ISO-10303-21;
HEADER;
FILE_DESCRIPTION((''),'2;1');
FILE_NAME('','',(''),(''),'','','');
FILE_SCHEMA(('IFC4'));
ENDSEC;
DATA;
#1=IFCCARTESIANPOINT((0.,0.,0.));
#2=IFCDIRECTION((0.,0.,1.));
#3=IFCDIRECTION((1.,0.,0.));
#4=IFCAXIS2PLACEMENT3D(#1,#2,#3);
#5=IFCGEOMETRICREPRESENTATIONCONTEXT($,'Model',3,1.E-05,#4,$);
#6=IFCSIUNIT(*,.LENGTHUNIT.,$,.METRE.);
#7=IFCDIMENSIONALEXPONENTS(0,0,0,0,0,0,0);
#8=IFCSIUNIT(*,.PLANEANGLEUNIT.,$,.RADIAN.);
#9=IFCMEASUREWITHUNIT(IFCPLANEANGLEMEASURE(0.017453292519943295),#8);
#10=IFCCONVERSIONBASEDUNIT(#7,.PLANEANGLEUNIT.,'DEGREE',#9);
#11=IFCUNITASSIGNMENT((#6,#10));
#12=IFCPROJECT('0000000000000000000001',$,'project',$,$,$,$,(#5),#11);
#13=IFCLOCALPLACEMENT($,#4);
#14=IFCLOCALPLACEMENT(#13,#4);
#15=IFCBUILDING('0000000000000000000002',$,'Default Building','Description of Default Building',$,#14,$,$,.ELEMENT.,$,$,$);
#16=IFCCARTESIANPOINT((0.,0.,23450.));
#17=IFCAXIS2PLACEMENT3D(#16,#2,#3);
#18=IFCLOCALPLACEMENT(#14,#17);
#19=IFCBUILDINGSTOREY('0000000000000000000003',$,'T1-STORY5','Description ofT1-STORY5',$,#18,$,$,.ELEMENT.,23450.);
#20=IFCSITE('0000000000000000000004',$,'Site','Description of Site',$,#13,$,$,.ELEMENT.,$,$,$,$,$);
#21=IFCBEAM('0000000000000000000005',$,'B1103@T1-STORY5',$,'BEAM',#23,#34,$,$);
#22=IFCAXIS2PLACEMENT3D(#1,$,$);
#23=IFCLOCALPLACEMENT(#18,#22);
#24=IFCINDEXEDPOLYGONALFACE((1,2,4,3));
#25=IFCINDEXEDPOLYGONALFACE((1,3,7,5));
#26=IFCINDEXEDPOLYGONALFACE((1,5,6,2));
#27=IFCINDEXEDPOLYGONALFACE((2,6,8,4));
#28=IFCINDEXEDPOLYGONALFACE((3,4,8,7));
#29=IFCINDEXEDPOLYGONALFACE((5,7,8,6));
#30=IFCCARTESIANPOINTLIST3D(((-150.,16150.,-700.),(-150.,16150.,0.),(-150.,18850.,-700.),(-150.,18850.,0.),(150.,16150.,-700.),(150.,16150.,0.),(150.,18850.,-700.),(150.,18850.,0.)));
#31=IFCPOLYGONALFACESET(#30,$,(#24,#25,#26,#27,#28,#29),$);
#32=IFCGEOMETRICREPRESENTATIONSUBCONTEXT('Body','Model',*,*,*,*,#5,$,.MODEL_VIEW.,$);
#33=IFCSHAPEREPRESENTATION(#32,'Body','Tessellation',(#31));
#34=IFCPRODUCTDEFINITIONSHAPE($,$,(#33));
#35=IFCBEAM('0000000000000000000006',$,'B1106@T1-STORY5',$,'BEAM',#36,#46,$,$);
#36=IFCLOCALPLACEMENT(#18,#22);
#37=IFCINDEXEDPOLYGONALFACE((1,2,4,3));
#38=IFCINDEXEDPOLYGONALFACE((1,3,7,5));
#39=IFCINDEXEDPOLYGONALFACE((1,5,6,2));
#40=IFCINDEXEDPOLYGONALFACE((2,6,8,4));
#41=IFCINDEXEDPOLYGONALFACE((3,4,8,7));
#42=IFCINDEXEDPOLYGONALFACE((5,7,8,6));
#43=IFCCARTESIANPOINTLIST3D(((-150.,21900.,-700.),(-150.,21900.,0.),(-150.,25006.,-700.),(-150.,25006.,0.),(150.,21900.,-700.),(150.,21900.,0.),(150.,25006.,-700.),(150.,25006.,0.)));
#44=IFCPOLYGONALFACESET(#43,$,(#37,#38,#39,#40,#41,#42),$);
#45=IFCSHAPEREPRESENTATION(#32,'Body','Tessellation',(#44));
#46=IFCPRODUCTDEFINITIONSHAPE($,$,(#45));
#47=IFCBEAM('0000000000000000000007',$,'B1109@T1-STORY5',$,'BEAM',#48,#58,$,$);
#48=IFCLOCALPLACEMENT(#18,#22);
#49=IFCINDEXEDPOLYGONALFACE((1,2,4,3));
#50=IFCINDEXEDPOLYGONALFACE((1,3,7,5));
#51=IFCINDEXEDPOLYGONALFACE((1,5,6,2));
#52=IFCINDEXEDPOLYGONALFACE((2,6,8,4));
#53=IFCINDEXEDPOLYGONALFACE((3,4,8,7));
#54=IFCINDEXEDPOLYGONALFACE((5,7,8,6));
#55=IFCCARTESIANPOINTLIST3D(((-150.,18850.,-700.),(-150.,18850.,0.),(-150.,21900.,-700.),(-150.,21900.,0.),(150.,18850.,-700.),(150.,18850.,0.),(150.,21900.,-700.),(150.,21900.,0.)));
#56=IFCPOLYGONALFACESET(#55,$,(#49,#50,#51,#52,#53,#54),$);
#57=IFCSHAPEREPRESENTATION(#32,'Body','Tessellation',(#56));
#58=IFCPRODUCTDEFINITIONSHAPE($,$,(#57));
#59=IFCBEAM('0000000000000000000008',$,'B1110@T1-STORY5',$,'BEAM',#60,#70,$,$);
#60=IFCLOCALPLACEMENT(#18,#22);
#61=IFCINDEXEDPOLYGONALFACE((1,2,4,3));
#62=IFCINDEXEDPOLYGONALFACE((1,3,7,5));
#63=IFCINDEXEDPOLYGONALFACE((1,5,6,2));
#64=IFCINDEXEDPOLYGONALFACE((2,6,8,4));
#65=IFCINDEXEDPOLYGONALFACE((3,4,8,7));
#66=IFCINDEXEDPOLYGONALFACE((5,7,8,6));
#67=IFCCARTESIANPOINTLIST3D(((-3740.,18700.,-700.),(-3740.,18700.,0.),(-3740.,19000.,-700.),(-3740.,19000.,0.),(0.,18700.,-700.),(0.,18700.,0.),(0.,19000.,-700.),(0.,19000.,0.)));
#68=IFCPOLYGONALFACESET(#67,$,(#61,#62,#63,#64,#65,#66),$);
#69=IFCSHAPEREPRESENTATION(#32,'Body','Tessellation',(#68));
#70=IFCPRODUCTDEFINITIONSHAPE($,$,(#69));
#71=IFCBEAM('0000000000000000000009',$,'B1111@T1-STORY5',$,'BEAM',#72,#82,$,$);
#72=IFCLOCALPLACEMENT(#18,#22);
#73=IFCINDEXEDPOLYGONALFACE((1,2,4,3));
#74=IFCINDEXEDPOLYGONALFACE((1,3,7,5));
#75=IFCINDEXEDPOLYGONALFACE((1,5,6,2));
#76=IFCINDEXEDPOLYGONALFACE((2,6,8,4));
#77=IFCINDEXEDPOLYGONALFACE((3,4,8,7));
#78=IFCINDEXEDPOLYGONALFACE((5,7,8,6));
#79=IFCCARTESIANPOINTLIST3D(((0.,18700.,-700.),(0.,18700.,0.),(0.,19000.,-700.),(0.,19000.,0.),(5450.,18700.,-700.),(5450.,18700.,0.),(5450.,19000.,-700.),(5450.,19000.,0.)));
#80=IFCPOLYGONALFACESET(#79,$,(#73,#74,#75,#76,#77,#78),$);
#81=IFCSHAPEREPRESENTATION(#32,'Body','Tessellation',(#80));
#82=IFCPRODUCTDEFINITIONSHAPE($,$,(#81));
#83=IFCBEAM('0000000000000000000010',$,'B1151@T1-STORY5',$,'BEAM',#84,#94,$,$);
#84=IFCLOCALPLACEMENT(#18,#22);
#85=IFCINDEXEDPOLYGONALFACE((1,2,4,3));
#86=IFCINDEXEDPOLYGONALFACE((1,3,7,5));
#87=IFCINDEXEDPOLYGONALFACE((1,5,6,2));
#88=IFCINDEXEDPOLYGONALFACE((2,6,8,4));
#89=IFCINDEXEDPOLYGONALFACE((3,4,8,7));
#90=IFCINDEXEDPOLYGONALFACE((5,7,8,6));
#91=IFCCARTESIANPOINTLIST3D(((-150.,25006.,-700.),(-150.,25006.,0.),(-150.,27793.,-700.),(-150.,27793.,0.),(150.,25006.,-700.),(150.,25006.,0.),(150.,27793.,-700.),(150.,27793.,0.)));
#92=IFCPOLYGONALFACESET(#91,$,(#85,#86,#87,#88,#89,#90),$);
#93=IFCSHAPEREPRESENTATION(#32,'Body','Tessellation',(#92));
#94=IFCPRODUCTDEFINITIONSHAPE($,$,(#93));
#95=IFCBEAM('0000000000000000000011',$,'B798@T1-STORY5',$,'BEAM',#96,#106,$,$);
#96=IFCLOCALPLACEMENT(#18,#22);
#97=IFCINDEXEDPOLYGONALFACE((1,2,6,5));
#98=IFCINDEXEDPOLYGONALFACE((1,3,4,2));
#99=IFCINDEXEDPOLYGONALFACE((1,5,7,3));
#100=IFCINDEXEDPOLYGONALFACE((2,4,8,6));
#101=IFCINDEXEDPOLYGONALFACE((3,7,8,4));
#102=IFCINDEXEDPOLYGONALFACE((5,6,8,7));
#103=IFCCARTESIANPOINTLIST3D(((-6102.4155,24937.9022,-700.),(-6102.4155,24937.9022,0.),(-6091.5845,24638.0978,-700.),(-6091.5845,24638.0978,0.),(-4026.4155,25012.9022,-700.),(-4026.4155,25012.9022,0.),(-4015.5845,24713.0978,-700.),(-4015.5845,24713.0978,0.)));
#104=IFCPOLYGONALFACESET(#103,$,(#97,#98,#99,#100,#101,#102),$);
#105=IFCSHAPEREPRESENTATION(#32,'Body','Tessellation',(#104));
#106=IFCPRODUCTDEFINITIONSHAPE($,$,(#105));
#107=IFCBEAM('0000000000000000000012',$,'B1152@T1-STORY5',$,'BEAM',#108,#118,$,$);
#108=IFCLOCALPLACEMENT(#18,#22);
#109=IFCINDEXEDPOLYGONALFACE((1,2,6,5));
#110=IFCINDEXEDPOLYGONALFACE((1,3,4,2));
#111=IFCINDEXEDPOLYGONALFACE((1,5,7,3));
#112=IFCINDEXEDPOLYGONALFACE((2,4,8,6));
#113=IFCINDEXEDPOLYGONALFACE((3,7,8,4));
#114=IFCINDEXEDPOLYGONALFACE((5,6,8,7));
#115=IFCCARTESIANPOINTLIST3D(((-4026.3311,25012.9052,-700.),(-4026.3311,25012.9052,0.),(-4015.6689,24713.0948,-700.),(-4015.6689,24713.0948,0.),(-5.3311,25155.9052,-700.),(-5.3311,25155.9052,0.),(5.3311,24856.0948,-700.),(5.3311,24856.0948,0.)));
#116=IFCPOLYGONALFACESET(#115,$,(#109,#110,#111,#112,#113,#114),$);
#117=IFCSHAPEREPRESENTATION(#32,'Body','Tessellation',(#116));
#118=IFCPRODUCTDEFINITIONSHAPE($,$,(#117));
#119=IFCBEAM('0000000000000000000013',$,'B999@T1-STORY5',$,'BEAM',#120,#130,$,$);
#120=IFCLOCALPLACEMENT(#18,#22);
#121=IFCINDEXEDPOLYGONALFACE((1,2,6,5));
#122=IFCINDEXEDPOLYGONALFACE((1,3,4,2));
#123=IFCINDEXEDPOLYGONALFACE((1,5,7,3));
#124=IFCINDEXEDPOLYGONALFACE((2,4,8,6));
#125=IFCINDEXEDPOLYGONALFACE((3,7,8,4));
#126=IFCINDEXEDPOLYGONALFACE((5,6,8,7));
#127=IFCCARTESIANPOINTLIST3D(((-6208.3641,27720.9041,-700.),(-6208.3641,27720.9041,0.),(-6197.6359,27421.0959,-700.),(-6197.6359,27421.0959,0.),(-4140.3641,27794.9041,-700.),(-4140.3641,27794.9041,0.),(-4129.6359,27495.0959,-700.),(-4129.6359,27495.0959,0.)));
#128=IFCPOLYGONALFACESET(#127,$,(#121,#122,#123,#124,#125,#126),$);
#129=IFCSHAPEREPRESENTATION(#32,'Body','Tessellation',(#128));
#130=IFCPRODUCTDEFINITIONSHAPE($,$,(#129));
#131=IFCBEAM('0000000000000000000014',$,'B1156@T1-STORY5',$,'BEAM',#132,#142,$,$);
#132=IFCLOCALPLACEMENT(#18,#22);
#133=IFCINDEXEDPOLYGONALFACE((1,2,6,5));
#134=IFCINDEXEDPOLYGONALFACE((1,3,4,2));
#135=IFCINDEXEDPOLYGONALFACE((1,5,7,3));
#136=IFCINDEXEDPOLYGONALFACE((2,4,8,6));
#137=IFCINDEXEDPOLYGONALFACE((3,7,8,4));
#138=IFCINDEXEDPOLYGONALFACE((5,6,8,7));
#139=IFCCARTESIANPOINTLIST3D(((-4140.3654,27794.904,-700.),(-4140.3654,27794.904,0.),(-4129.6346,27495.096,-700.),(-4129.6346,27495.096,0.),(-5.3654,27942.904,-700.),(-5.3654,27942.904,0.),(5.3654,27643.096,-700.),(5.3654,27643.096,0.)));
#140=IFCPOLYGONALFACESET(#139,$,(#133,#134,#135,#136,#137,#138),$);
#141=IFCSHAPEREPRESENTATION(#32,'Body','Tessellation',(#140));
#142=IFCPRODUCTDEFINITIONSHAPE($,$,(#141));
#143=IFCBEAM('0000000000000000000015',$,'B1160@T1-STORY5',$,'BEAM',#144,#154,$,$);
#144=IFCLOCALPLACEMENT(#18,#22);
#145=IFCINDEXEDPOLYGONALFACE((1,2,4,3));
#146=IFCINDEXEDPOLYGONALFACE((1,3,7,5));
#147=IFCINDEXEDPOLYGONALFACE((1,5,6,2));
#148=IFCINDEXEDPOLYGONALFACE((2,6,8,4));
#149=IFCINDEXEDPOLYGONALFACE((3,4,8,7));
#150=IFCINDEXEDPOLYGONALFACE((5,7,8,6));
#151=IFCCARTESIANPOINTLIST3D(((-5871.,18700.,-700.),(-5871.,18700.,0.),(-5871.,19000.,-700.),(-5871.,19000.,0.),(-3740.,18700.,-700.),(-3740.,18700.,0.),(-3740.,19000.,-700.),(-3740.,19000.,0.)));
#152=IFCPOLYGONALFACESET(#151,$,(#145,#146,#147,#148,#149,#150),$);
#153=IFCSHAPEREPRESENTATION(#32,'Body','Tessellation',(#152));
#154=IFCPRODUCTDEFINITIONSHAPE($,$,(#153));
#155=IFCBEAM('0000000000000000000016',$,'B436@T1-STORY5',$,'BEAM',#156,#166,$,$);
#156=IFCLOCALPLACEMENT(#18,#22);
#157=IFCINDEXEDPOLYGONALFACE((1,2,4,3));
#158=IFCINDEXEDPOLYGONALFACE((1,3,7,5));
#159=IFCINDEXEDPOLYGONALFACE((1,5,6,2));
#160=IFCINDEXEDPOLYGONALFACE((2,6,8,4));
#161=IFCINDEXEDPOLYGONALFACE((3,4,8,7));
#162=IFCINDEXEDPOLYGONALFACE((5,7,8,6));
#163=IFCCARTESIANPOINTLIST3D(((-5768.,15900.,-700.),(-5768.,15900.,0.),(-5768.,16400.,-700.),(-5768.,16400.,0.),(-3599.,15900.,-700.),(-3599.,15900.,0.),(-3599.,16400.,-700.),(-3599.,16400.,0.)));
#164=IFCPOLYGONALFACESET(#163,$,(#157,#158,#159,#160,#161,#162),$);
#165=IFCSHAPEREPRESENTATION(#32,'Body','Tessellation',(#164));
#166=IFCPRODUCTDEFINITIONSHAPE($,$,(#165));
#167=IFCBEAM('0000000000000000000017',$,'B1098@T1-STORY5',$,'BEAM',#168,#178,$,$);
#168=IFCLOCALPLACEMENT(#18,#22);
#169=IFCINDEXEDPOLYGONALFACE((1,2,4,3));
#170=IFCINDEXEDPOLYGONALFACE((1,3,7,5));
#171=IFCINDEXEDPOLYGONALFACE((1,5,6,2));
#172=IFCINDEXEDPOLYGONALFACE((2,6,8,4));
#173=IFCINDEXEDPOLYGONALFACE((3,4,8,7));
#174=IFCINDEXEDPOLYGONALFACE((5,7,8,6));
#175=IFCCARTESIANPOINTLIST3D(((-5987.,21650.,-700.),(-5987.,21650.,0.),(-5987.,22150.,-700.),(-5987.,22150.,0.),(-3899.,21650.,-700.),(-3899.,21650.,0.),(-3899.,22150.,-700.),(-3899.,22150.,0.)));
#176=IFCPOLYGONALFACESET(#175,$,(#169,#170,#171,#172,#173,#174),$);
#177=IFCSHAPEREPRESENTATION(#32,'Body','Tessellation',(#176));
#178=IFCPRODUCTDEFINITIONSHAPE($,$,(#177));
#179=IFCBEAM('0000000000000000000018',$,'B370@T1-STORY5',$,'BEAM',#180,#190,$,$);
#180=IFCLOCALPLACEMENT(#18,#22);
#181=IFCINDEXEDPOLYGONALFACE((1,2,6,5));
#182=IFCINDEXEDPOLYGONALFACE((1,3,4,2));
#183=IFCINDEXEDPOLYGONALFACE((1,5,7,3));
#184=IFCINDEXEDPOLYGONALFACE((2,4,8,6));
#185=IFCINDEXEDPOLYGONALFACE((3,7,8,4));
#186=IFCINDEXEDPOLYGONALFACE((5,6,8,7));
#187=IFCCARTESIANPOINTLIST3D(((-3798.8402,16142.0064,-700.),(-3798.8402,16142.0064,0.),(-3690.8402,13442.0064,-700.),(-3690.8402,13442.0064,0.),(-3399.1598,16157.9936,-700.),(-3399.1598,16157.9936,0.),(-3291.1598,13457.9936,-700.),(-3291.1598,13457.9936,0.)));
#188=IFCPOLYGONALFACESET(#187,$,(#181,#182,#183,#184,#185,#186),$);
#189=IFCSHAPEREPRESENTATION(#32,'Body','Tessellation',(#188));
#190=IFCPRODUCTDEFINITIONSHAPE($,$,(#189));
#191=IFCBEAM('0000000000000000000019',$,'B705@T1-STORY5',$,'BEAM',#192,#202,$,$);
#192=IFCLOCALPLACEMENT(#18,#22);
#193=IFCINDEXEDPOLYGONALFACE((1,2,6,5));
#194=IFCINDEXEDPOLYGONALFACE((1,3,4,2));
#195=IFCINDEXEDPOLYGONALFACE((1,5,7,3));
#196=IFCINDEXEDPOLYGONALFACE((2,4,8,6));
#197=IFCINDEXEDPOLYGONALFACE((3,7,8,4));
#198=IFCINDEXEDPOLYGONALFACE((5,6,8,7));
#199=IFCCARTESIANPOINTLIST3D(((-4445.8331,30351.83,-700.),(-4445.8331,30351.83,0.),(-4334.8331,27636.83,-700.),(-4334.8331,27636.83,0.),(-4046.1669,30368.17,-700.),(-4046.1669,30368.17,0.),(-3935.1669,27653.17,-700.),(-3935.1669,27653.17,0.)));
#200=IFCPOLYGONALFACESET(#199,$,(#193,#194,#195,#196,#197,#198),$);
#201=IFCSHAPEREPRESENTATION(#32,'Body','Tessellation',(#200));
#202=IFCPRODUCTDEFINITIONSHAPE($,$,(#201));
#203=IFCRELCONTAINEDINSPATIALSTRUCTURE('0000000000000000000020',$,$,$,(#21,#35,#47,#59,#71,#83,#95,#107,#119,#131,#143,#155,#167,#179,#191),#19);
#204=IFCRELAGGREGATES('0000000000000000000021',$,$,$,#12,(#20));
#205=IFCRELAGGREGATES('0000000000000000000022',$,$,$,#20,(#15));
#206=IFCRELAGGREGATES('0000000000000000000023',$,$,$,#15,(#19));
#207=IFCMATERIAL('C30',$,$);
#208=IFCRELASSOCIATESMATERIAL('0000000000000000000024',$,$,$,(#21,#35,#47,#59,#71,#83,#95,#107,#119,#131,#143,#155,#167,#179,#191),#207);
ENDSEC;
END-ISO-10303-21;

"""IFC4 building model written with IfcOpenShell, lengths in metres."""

from ifc_helpers import new_model, entity, si_unit, converted_unit, frame, origin_with_axes, place, context, subcontext, project, spatial, rectangle, extrude, material, element, save


model = new_model("IFC4")

# Units and contexts
model_context = context("Model", 3, precision=1e-05, world=origin_with_axes())
body_context = subcontext(model_context, "Body", "Model", "MODEL_VIEW")
ifc_project = project(units=[si_unit("LENGTHUNIT", "METRE"), converted_unit("PLANEANGLEUNIT", "DEGREE", entity("IfcPlaneAngleMeasure", 0.017453292519943295), si_unit("PLANEANGLEUNIT", "RADIAN"), dimensions=[0, 0, 0, 0, 0, 0, 0])], contexts=[model_context])

# Site, building, storey
site_placement = place(None, origin_with_axes())
site = spatial("IfcSite", under=ifc_project, at=site_placement, Name="Site", Description="Description of Site", CompositionType="ELEMENT")
building_placement = place(site_placement, origin_with_axes())
building = spatial("IfcBuilding", under=site, at=building_placement, Name="Default Building", Description="Description of Default Building", CompositionType="ELEMENT")
storey_placement = place(building_placement, frame((0.0, 0.0, 23450.0), z_axis=(0.0, 0.0, 1.0), x_axis=(1.0, 0.0, 0.0)))
storey = spatial("IfcBuildingStorey", under=building, at=storey_placement, Name="T1-STORY5", Description="Description ofT1-STORY5", CompositionType="ELEMENT", Elevation=23450.0)

# Beams
ifc_material_1 = material(Name="C30")
beam_1_placement = place(storey_placement, frame((0.0, 16150.0, -350.0), z_axis=(0.0, 1.0, 0.0), x_axis=(-1.0, 0.0, 0.0)))
element("IfcBeam", 1, at=beam_1_placement, inside=storey, material=ifc_material_1, Name="B1103@T1-STORY5", ObjectType="BEAM", context=body_context, shape_type="SweptSolid", body=[
    extrude(rectangle(XDim=300.0, YDim=700.0), origin_with_axes(), (0.0, 0.0, 1.0), 2700.0),
])
beam_2_placement = place(storey_placement, frame((0.0, 21900.0, -350.0), z_axis=(0.0, 1.0, 0.0), x_axis=(-1.0, 0.0, 0.0)))
element("IfcBeam", 2, at=beam_2_placement, inside=storey, material=ifc_material_1, Name="B1106@T1-STORY5", ObjectType="BEAM", context=body_context, shape_type="SweptSolid", body=[
    extrude(rectangle(XDim=300.0, YDim=700.0), origin_with_axes(), (0.0, 0.0, 1.0), 3106.0),
])
beam_3_placement = place(storey_placement, frame((0.0, 18850.0, -350.0), z_axis=(0.0, 1.0, 0.0), x_axis=(-1.0, 0.0, 0.0)))
element("IfcBeam", 3, at=beam_3_placement, inside=storey, material=ifc_material_1, Name="B1109@T1-STORY5", ObjectType="BEAM", context=body_context, shape_type="SweptSolid", body=[
    extrude(rectangle(XDim=300.0, YDim=700.0), origin_with_axes(), (0.0, 0.0, 1.0), 3050.0),
])
beam_4_placement = place(storey_placement, frame((-3740.0, 18850.0, -350.0), z_axis=(1.0, 0.0, 0.0), x_axis=(0.0, 1.0, 0.0)))
element("IfcBeam", 4, at=beam_4_placement, inside=storey, material=ifc_material_1, Name="B1110@T1-STORY5", ObjectType="BEAM", context=body_context, shape_type="SweptSolid", body=[
    extrude(rectangle(XDim=300.0, YDim=700.0), origin_with_axes(), (0.0, 0.0, 1.0), 3740.0),
])
beam_5_placement = place(storey_placement, frame((0.0, 18850.0, -350.0), z_axis=(1.0, 0.0, 0.0), x_axis=(0.0, 1.0, 0.0)))
element("IfcBeam", 5, at=beam_5_placement, inside=storey, material=ifc_material_1, Name="B1111@T1-STORY5", ObjectType="BEAM", context=body_context, shape_type="SweptSolid", body=[
    extrude(rectangle(XDim=300.0, YDim=700.0), origin_with_axes(), (0.0, 0.0, 1.0), 5450.0),
])
beam_6_placement = place(storey_placement, frame((0.0, 25006.0, -350.0), z_axis=(0.0, 1.0, 0.0), x_axis=(-1.0, 0.0, 0.0)))
element("IfcBeam", 6, at=beam_6_placement, inside=storey, material=ifc_material_1, Name="B1151@T1-STORY5", ObjectType="BEAM", context=body_context, shape_type="SweptSolid", body=[
    extrude(rectangle(XDim=300.0, YDim=700.0), origin_with_axes(), (0.0, 0.0, 1.0), 2787.0),
])
beam_7_placement = place(storey_placement, frame((-6097.0, 24788.0, -350.0), z_axis=(0.999348, 0.036104, 0.0), x_axis=(-0.036104, 0.999348, 0.0)))
element("IfcBeam", 7, at=beam_7_placement, inside=storey, material=ifc_material_1, Name="B798@T1-STORY5", ObjectType="BEAM", context=body_context, shape_type="SweptSolid", body=[
    extrude(rectangle(XDim=300.0, YDim=700.0), origin_with_axes(), (0.0, 0.0, 1.0), 2077.3543),
])
beam_8_placement = place(storey_placement, frame((-4021.0, 24863.0, -350.0), z_axis=(0.999368, 0.035541, 0.0), x_axis=(-0.035541, 0.999368, 0.0)))
element("IfcBeam", 8, at=beam_8_placement, inside=storey, material=ifc_material_1, Name="B1152@T1-STORY5", ObjectType="BEAM", context=body_context, shape_type="SweptSolid", body=[
    extrude(rectangle(XDim=300.0, YDim=700.0), origin_with_axes(), (0.0, 0.0, 1.0), 4023.542),
])
beam_9_placement = place(storey_placement, frame((-6203.0, 27571.0, -350.0), z_axis=(0.99936, 0.03576, 0.0), x_axis=(-0.03576, 0.99936, 0.0)))
element("IfcBeam", 9, at=beam_9_placement, inside=storey, material=ifc_material_1, Name="B999@T1-STORY5", ObjectType="BEAM", context=body_context, shape_type="SweptSolid", body=[
    extrude(rectangle(XDim=300.0, YDim=700.0), origin_with_axes(), (0.0, 0.0, 1.0), 2069.3236),
])
beam_10_placement = place(storey_placement, frame((-4135.0, 27645.0, -350.0), z_axis=(0.99936, 0.035769, 0.0), x_axis=(-0.035769, 0.99936, 0.0)))
element("IfcBeam", 10, at=beam_10_placement, inside=storey, material=ifc_material_1, Name="B1156@T1-STORY5", ObjectType="BEAM", context=body_context, shape_type="SweptSolid", body=[
    extrude(rectangle(XDim=300.0, YDim=700.0), origin_with_axes(), (0.0, 0.0, 1.0), 4137.6478),
])
beam_11_placement = place(storey_placement, frame((-5871.0, 18850.0, -350.0), z_axis=(1.0, 0.0, 0.0), x_axis=(0.0, 1.0, 0.0)))
element("IfcBeam", 11, at=beam_11_placement, inside=storey, material=ifc_material_1, Name="B1160@T1-STORY5", ObjectType="BEAM", context=body_context, shape_type="SweptSolid", body=[
    extrude(rectangle(XDim=300.0, YDim=700.0), origin_with_axes(), (0.0, 0.0, 1.0), 2131.0),
])
beam_12_placement = place(storey_placement, frame((-5768.0, 16150.0, -350.0), z_axis=(1.0, 0.0, 0.0), x_axis=(0.0, 1.0, 0.0)))
element("IfcBeam", 12, at=beam_12_placement, inside=storey, material=ifc_material_1, Name="B436@T1-STORY5", ObjectType="BEAM", context=body_context, shape_type="SweptSolid", body=[
    extrude(rectangle(XDim=500.0, YDim=700.0), origin_with_axes(), (0.0, 0.0, 1.0), 2169.0),
])
beam_13_placement = place(storey_placement, frame((-5987.0, 21900.0, -350.0), z_axis=(1.0, 0.0, 0.0), x_axis=(0.0, 1.0, 0.0)))
element("IfcBeam", 13, at=beam_13_placement, inside=storey, material=ifc_material_1, Name="B1098@T1-STORY5", ObjectType="BEAM", context=body_context, shape_type="SweptSolid", body=[
    extrude(rectangle(XDim=500.0, YDim=700.0), origin_with_axes(), (0.0, 0.0, 1.0), 2088.0),
])
beam_14_placement = place(storey_placement, frame((-3599.0, 16150.0, -350.0), z_axis=(0.039968, -0.999201, 0.0), x_axis=(0.999201, 0.039968, 0.0)))
element("IfcBeam", 14, at=beam_14_placement, inside=storey, material=ifc_material_1, Name="B370@T1-STORY5", ObjectType="BEAM", context=body_context, shape_type="SweptSolid", body=[
    extrude(rectangle(XDim=400.0, YDim=700.0), origin_with_axes(), (0.0, 0.0, 1.0), 2702.1591),
])
beam_15_placement = place(storey_placement, frame((-4246.0, 30360.0, -350.0), z_axis=(0.04085, -0.999165, 0.0), x_axis=(0.999165, 0.04085, 0.0)))
element("IfcBeam", 15, at=beam_15_placement, inside=storey, material=ifc_material_1, Name="B705@T1-STORY5", ObjectType="BEAM", context=body_context, shape_type="SweptSolid", body=[
    extrude(rectangle(XDim=400.0, YDim=700.0), origin_with_axes(), (0.0, 0.0, 1.0), 2717.2681),
])

save(model, "model.ifc")
